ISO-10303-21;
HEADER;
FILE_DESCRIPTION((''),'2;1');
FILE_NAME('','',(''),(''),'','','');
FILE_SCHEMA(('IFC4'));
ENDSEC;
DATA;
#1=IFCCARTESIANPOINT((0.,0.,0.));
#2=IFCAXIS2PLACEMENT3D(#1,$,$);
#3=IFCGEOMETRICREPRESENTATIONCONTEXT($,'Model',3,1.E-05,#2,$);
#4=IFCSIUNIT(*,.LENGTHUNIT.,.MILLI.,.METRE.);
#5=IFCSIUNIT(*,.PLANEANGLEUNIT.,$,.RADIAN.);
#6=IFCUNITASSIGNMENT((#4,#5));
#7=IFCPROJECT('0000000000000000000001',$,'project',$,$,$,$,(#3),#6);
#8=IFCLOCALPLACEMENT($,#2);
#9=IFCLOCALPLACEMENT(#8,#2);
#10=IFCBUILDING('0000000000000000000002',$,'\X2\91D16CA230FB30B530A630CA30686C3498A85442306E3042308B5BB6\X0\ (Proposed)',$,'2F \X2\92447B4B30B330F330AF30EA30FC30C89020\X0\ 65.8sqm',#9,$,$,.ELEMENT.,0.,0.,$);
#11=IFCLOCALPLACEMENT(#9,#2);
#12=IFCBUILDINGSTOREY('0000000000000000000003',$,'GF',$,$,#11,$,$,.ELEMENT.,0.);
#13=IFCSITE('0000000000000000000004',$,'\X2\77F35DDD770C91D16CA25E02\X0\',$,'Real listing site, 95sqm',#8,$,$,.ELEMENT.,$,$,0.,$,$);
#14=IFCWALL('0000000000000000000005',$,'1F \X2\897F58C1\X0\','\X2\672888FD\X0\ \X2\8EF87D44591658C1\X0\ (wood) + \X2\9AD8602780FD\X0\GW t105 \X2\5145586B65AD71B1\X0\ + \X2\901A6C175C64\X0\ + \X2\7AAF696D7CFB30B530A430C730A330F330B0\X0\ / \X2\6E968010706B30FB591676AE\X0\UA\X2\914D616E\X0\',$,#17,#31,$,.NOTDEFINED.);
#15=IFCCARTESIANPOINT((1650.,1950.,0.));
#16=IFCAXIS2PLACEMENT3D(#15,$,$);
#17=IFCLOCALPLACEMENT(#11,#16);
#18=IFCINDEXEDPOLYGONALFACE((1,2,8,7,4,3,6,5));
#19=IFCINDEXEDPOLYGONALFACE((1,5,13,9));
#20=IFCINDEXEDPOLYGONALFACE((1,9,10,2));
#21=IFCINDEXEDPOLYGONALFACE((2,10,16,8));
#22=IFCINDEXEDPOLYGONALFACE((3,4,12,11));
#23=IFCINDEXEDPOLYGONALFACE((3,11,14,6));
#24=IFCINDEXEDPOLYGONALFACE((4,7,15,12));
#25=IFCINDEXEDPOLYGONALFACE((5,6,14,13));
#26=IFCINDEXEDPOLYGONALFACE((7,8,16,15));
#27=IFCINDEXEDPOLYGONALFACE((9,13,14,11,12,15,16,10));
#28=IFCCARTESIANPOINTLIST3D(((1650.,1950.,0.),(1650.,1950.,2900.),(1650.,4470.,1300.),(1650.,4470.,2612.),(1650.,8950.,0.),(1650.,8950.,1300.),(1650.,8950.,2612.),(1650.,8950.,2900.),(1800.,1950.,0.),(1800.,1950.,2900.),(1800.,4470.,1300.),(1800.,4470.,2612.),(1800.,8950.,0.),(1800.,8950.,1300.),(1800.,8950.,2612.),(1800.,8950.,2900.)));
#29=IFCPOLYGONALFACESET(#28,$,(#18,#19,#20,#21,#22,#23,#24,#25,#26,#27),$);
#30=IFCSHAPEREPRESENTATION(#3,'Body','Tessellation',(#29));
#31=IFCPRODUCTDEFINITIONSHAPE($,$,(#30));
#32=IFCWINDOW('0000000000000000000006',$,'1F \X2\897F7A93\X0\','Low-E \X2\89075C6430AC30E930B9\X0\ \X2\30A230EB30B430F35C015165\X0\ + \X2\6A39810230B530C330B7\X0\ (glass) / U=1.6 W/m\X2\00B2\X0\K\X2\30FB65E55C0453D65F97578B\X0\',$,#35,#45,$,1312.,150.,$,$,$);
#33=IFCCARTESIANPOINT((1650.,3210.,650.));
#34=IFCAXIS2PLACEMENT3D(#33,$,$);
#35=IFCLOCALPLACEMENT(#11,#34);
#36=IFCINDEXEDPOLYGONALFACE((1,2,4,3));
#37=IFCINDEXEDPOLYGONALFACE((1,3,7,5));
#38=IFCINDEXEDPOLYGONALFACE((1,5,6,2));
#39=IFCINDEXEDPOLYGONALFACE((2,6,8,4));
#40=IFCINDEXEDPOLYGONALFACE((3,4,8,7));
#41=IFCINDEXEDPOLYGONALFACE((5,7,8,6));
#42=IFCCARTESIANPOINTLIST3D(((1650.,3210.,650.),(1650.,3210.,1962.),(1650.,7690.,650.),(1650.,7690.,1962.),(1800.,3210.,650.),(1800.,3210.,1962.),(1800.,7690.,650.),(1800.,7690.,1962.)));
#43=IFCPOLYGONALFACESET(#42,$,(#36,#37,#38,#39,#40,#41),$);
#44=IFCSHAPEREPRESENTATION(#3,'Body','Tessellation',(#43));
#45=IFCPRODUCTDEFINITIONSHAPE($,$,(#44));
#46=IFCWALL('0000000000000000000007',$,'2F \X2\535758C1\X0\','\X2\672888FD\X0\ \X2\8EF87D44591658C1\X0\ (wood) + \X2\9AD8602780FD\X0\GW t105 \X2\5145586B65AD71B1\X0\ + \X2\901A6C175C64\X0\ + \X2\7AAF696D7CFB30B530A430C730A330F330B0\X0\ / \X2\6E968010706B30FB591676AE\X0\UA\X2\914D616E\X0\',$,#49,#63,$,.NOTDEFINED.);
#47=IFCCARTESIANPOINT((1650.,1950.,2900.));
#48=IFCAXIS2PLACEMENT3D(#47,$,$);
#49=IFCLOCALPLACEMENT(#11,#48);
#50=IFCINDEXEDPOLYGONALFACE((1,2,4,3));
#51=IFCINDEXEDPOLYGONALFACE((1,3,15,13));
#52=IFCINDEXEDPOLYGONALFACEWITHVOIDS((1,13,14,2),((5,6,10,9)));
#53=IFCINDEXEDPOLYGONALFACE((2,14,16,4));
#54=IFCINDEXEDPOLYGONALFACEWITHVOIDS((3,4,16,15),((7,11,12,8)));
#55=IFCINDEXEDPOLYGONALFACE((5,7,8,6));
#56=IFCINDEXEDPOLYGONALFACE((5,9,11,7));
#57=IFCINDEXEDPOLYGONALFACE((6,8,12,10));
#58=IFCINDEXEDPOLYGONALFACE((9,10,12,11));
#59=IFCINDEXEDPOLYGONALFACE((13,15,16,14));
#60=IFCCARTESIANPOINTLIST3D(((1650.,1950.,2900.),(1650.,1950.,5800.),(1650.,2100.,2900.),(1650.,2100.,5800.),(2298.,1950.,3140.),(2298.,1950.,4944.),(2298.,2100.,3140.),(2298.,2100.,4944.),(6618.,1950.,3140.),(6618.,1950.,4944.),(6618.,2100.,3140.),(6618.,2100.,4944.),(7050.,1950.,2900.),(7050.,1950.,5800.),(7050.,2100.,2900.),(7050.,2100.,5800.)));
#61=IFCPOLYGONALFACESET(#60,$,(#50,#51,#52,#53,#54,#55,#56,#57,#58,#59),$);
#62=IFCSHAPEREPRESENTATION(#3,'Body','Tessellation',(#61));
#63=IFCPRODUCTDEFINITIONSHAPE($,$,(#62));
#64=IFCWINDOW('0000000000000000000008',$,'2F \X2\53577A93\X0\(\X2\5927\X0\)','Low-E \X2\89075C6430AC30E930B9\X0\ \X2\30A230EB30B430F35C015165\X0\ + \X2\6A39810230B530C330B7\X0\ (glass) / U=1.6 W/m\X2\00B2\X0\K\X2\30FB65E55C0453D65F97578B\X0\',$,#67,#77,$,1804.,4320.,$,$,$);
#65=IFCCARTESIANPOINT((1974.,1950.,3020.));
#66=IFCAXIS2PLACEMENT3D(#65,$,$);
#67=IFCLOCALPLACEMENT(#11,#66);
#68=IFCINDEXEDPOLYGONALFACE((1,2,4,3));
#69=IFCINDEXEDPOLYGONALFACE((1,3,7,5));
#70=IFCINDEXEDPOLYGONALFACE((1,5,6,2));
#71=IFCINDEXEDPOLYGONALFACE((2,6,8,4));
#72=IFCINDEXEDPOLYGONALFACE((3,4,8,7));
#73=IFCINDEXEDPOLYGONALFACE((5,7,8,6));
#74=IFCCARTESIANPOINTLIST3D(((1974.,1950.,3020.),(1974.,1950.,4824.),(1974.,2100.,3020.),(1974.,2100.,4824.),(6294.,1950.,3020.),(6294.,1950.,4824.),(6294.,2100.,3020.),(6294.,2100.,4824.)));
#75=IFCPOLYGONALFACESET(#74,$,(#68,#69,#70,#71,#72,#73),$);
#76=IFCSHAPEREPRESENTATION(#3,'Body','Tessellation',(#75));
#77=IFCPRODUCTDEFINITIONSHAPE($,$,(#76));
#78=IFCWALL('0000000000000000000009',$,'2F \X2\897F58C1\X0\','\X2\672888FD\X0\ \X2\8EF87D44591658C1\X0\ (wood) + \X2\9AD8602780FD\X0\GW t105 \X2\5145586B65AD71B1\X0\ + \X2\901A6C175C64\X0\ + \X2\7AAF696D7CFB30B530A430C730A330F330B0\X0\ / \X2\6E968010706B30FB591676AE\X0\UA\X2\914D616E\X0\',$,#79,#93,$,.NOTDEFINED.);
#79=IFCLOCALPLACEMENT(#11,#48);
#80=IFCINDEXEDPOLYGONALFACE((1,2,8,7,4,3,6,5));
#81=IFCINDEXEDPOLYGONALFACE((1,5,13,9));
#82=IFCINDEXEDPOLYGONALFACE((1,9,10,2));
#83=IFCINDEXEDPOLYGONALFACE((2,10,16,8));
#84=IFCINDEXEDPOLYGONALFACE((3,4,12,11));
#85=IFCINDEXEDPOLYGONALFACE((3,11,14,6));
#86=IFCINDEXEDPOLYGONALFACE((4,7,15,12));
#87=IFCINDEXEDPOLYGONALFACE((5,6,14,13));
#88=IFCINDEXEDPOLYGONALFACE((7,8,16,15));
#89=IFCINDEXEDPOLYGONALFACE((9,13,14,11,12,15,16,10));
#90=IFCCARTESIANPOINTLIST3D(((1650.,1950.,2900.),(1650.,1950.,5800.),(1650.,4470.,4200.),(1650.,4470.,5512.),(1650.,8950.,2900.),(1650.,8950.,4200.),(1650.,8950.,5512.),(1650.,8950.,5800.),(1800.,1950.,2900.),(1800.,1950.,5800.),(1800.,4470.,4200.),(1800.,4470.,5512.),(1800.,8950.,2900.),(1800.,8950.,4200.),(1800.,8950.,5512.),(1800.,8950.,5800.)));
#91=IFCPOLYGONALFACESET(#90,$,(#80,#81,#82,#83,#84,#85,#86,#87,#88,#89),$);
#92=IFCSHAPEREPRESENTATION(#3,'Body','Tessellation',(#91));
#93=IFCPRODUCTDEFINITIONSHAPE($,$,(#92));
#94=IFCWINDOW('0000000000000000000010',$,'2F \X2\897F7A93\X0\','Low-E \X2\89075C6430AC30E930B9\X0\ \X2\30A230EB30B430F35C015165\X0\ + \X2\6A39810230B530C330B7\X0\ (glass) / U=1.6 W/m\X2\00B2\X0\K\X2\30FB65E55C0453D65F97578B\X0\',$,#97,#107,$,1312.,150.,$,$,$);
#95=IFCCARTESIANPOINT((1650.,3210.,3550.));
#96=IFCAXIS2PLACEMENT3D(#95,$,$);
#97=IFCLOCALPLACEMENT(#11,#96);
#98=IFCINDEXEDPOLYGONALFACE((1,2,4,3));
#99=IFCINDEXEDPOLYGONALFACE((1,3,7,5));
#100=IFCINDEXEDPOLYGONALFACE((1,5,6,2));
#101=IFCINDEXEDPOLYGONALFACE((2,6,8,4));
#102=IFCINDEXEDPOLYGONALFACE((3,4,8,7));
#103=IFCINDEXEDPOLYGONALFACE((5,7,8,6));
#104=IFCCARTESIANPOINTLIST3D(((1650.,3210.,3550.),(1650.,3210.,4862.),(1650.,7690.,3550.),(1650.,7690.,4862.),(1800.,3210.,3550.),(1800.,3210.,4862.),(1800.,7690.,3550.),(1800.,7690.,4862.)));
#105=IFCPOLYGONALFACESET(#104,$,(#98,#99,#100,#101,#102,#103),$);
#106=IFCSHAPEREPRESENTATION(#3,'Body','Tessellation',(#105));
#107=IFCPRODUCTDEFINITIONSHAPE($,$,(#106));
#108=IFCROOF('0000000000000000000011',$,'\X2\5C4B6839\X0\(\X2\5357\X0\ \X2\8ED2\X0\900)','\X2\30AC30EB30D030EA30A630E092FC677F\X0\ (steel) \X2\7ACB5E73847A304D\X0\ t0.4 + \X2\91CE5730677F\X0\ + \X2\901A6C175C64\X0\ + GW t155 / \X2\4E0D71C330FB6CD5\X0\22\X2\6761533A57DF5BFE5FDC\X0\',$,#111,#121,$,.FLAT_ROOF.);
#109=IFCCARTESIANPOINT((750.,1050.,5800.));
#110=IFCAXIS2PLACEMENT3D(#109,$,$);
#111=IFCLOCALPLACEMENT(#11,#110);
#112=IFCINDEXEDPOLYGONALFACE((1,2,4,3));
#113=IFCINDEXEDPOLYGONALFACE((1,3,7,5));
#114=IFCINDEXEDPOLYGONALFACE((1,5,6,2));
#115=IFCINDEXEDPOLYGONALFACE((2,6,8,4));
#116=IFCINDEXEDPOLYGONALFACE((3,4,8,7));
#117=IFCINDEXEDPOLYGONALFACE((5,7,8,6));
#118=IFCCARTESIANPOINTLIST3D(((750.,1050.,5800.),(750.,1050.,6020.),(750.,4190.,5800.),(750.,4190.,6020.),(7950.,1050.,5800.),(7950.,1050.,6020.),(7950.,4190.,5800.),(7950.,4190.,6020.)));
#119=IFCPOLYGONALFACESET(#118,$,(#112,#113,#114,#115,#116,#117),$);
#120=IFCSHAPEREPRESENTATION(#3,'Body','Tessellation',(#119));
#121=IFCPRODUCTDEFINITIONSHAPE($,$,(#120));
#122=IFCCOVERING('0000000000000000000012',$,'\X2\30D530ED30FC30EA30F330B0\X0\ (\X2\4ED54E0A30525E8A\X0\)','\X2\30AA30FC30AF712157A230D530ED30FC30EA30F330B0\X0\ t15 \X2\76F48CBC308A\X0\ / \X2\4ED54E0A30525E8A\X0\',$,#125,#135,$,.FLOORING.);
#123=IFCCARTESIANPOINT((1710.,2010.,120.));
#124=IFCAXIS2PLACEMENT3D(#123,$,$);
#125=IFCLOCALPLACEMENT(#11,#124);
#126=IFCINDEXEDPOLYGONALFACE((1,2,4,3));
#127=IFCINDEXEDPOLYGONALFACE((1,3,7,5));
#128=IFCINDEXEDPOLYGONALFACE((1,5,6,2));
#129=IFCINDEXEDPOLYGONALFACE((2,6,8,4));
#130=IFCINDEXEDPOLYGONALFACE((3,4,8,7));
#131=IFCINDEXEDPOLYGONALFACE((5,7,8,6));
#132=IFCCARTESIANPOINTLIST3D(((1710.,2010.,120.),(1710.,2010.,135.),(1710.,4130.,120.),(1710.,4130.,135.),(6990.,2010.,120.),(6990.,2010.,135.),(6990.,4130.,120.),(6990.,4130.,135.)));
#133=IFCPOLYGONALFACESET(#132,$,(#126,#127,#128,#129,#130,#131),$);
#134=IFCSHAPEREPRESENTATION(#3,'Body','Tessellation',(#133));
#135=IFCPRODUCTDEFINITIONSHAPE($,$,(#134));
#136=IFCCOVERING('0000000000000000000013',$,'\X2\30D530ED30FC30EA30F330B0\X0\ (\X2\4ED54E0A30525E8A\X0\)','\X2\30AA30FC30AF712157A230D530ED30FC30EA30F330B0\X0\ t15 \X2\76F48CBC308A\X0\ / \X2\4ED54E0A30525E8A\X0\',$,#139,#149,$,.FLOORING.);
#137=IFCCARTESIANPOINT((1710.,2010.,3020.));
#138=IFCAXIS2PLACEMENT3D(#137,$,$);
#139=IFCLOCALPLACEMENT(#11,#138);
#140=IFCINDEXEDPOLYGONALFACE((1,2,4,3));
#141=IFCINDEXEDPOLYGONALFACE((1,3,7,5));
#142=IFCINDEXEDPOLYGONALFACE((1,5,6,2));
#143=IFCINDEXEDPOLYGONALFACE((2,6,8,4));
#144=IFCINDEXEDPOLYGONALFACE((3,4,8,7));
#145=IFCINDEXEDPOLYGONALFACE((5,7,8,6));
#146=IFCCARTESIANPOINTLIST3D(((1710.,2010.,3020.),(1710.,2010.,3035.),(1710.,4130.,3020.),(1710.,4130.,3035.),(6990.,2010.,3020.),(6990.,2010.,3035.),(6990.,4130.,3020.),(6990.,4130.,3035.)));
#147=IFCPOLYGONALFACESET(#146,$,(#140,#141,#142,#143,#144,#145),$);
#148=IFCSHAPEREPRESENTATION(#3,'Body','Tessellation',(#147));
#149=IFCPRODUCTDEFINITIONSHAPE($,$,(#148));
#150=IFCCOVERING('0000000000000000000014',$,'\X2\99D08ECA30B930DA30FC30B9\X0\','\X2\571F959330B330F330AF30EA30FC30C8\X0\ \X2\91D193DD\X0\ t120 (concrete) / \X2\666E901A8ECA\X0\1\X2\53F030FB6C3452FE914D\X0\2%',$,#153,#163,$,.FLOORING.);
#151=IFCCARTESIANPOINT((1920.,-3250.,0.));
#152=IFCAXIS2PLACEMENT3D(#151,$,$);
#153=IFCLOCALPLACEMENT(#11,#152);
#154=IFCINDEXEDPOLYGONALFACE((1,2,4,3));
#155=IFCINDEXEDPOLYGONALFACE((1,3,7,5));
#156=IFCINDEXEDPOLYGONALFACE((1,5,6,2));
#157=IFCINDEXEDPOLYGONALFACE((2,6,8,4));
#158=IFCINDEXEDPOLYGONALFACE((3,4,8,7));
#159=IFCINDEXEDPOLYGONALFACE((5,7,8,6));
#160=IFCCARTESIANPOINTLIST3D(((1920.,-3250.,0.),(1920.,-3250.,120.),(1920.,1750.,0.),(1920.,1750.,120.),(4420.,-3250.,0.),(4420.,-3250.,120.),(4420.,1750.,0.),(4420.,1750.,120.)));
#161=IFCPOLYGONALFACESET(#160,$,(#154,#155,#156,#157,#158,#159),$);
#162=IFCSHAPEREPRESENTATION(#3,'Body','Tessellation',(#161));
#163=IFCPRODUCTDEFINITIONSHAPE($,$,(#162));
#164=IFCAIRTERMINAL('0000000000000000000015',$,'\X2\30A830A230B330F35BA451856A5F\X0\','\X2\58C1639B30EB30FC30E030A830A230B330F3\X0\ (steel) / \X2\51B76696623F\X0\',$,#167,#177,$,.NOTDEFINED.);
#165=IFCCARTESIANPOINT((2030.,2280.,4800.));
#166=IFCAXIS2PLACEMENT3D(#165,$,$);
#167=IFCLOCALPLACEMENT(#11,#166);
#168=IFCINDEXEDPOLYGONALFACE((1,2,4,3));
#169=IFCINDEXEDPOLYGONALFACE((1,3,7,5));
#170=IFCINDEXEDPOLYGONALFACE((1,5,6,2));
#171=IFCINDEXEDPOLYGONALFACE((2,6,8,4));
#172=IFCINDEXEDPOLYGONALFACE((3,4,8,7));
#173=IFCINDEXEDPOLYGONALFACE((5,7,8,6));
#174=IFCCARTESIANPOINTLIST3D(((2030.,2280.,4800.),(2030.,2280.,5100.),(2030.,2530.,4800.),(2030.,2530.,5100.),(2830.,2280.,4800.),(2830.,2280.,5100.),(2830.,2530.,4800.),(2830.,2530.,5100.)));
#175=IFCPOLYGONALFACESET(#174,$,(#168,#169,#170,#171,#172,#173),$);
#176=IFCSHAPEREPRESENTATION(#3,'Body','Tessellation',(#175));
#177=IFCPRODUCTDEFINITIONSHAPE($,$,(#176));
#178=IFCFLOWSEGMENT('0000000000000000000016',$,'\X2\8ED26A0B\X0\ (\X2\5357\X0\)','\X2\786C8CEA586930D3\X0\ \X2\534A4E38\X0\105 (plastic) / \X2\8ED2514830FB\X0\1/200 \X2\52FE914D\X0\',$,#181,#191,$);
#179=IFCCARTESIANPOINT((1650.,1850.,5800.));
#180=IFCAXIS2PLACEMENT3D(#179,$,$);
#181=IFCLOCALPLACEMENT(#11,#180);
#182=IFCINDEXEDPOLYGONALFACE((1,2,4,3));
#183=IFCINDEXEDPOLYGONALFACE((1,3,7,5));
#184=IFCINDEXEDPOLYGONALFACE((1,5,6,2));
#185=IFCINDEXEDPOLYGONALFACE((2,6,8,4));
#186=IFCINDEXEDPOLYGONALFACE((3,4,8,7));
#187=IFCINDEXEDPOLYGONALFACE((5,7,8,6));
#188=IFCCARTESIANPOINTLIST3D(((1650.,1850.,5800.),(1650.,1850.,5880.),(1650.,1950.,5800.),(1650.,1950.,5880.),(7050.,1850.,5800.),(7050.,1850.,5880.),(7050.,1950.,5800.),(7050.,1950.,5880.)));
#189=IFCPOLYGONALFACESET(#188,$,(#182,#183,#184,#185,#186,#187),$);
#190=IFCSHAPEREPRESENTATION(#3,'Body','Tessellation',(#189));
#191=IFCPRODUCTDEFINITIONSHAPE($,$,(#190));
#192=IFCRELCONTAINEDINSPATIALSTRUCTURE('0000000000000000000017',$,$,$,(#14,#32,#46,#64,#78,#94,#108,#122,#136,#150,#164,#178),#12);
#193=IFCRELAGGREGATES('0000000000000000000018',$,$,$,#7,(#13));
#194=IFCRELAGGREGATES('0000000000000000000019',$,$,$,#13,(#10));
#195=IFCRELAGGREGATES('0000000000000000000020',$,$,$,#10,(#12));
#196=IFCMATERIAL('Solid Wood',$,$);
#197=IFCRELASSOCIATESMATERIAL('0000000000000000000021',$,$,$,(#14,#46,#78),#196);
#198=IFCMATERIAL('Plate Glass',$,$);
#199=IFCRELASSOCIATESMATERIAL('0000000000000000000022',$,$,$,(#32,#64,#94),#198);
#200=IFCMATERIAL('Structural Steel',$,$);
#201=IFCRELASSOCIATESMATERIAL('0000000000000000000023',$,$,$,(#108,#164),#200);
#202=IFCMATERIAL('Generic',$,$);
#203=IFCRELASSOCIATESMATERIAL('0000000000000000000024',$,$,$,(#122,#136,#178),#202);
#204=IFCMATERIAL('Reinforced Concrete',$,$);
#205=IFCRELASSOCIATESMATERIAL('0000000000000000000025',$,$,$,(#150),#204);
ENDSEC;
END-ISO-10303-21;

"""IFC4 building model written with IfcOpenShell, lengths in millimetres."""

from ifc_helpers import new_model, si_unit, frame, frame_2d, origin, place, context, project, spatial, rectangle, extrude, material, element, fill, save


model = new_model("IFC4")

# Units and contexts
model_context = context("Model", 3, precision=1e-05, world=origin())
ifc_project = project(units=[si_unit("LENGTHUNIT", "METRE", prefix="MILLI"), si_unit("PLANEANGLEUNIT", "RADIAN")], contexts=[model_context])

# Site, building, storey
site_placement = place(None, origin())
site = spatial("IfcSite", under=ifc_project, at=site_placement, Name="石川県金沢市", ObjectType="Real listing site, 95sqm", CompositionType="ELEMENT", RefElevation=0.0)
building_placement = place(site_placement, origin())
building = spatial("IfcBuilding", under=site, at=building_placement, Name="金沢・サウナと水風呂のある家 (Proposed)", ObjectType="2F 鉄筋コンクリート造 65.8sqm", CompositionType="ELEMENT", ElevationOfRefHeight=0.0, ElevationOfTerrain=0.0)
storey_placement = place(building_placement, origin())
storey = spatial("IfcBuildingStorey", under=building, at=storey_placement, Name="GF", CompositionType="ELEMENT", Elevation=0.0)

# Shared definitions
ifc_material_1 = material(Name="Solid Wood")

# Shared definitions
ifc_material_2 = material(Name="Reinforced Concrete")

# Shared definitions
ifc_material_3 = material(Name="Plate Glass")

# Walls, openings, windows
wall_1_placement = place(storey_placement, frame((1650.0, 1950.0, 0.0)))
wall_1 = element("IfcWall", 1, at=wall_1_placement, inside=storey, material=ifc_material_1, Name="1F 西壁", Description="木製 軸組外壁 (wood) + 高性能GW t105 充填断熱 + 通気層 + 窯業系サイディング / 準耐火・外皮UA配慮", PredefinedType="NOTDEFINED", context=model_context, shape_type="SweptSolid", body=[
    extrude(rectangle(XDim=150.0, YDim=7000.0, at=frame_2d((75.0, 3500.0))), frame((1650.0, 1950.0, 0.0)), (0.0, 0.0, 1.0), 2900.0),
])
opening_1_placement = place(storey_placement, frame((1650.0, 3210.0, 650.0)))
opening_1 = element("IfcOpeningElement", 2, at=opening_1_placement, cuts=wall_1, PredefinedType="NOTDEFINED", context=model_context, shape_type="SweptSolid", body=[
    extrude(rectangle(XDim=150.0, YDim=4480.0, at=frame_2d((75.0, 2240.0))), frame((1650.0, 3210.0, 650.0)), (0.0, 0.0, 1.0), 1312.0),
])
window_1_placement = place(storey_placement, frame((1650.0, 3210.0, 650.0)))
window_1 = element("IfcWindow", 3, at=window_1_placement, inside=storey, material=ifc_material_3, Name="1F 西窓", Description="Low-E 複層ガラス アルゴン封入 + 樹脂サッシ (glass) / U=1.6 W/m²K・日射取得型", OverallHeight=1312.0, OverallWidth=150.0, context=model_context, shape_type="SweptSolid", body=[
    extrude(rectangle(XDim=150.0, YDim=4480.0, at=frame_2d((75.0, 2240.0))), frame((1650.0, 3210.0, 650.0)), (0.0, 0.0, 1.0), 1312.0),
])
fill(opening_1, window_1)
wall_2_placement = place(storey_placement, frame((1650.0, 1950.0, 2900.0)))
wall_2 = element("IfcWall", 4, at=wall_2_placement, inside=storey, material=ifc_material_1, Name="2F 南壁", Description="木製 軸組外壁 (wood) + 高性能GW t105 充填断熱 + 通気層 + 窯業系サイディング / 準耐火・外皮UA配慮", PredefinedType="NOTDEFINED", context=model_context, shape_type="SweptSolid", body=[
    extrude(rectangle(XDim=5400.0, YDim=150.0, at=frame_2d((2700.0, 75.0))), frame((1650.0, 1950.0, 2900.0)), (0.0, 0.0, 1.0), 2900.0),
])
opening_2_placement = place(storey_placement, frame((1974.0, 1950.0, 3020.0)))
opening_2 = element("IfcOpeningElement", 5, at=opening_2_placement, cuts=wall_2, PredefinedType="NOTDEFINED", context=model_context, shape_type="SweptSolid", body=[
    extrude(rectangle(XDim=4320.0, YDim=150.0, at=frame_2d((2160.0, 75.0))), frame((1974.0, 1950.0, 3020.0)), (0.0, 0.0, 1.0), 1804.0),
])
window_2_placement = place(storey_placement, frame((1974.0, 1950.0, 3020.0)))
window_2 = element("IfcWindow", 6, at=window_2_placement, inside=storey, material=ifc_material_3, Name="2F 南窓(大)", Description="Low-E 複層ガラス アルゴン封入 + 樹脂サッシ (glass) / U=1.6 W/m²K・日射取得型", OverallHeight=1804.0, OverallWidth=4320.0, context=model_context, shape_type="SweptSolid", body=[
    extrude(rectangle(XDim=4320.0, YDim=150.0, at=frame_2d((2160.0, 75.0))), frame((1974.0, 1950.0, 3020.0)), (0.0, 0.0, 1.0), 1804.0),
])
fill(opening_2, window_2)
wall_3_placement = place(storey_placement, frame((1650.0, 1950.0, 2900.0)))
wall_3 = element("IfcWall", 7, at=wall_3_placement, inside=storey, material=ifc_material_1, Name="2F 西壁", Description="木製 軸組外壁 (wood) + 高性能GW t105 充填断熱 + 通気層 + 窯業系サイディング / 準耐火・外皮UA配慮", PredefinedType="NOTDEFINED", context=model_context, shape_type="SweptSolid", body=[
    extrude(rectangle(XDim=150.0, YDim=7000.0, at=frame_2d((75.0, 3500.0))), frame((1650.0, 1950.0, 2900.0)), (0.0, 0.0, 1.0), 2900.0),
])
opening_3_placement = place(storey_placement, frame((1650.0, 3210.0, 3550.0)))
opening_3 = element("IfcOpeningElement", 8, at=opening_3_placement, cuts=wall_3, PredefinedType="NOTDEFINED", context=model_context, shape_type="SweptSolid", body=[
    extrude(rectangle(XDim=150.0, YDim=4480.0, at=frame_2d((75.0, 2240.0))), frame((1650.0, 3210.0, 3550.0)), (0.0, 0.0, 1.0), 1312.0),
])
window_3_placement = place(storey_placement, frame((1650.0, 3210.0, 3550.0)))
window_3 = element("IfcWindow", 9, at=window_3_placement, inside=storey, material=ifc_material_3, Name="2F 西窓", Description="Low-E 複層ガラス アルゴン封入 + 樹脂サッシ (glass) / U=1.6 W/m²K・日射取得型", OverallHeight=1312.0, OverallWidth=150.0, context=model_context, shape_type="SweptSolid", body=[
    extrude(rectangle(XDim=150.0, YDim=4480.0, at=frame_2d((75.0, 2240.0))), frame((1650.0, 3210.0, 3550.0)), (0.0, 0.0, 1.0), 1312.0),
])
fill(opening_3, window_3)

# Roof
ifc_material_4 = material(Name="Structural Steel")
for number, where, name in (
    (10, (750.0, 1050.0, 5800.0), "屋根(南 軒900)"),
):
    element("IfcRoof", number, at=place(storey_placement, frame(where)), inside=storey, material=ifc_material_4, Name=name, Description="ガルバリウム鋼板 (steel) 立平葺き t0.4 + 野地板 + 通気層 + GW t155 / 不燃・法22条区域対応", PredefinedType="FLAT_ROOF", context=model_context, shape_type="SweptSolid", body=[
        extrude(rectangle(XDim=7200.0, YDim=3140.0, at=frame_2d((3600.0, 1570.0))), frame((750.0, 1050.0, 5800.0)), (0.0, 0.0, 1.0), 220.0),
    ])

# Coverings
ifc_material_5 = material(Name="Generic")
covering_1_placement = place(storey_placement, frame((1710.0, 2010.0, 120.0)))
element("IfcCovering", 11, at=covering_1_placement, inside=storey, material=ifc_material_5, Name="フローリング (仕上げ床)", Description="オーク無垢フローリング t15 直貼り / 仕上げ床", PredefinedType="FLOORING", context=model_context, shape_type="SweptSolid", body=[
    extrude(rectangle(XDim=5280.0, YDim=2120.0, at=frame_2d((2640.0, 1060.0))), frame((1710.0, 2010.0, 120.0)), (0.0, 0.0, 1.0), 15.0),
])
covering_2_placement = place(storey_placement, frame((1710.0, 2010.0, 3020.0)))
element("IfcCovering", 12, at=covering_2_placement, inside=storey, material=ifc_material_5, Name="フローリング (仕上げ床)", Description="オーク無垢フローリング t15 直貼り / 仕上げ床", PredefinedType="FLOORING", context=model_context, shape_type="SweptSolid", body=[
    extrude(rectangle(XDim=5280.0, YDim=2120.0, at=frame_2d((2640.0, 1060.0))), frame((1710.0, 2010.0, 3020.0)), (0.0, 0.0, 1.0), 15.0),
])
covering_3_placement = place(storey_placement, frame((1920.0, -3250.0, 0.0)))
element("IfcCovering", 13, at=covering_3_placement, inside=storey, material=ifc_material_2, Name="駐車スペース", Description="土間コンクリート 金鏝 t120 (concrete) / 普通車1台・水勾配2%", PredefinedType="FLOORING", context=model_context, shape_type="SweptSolid", body=[
    extrude(rectangle(XDim=2500.0, YDim=5000.0, at=frame_2d((1250.0, 2500.0))), frame((1920.0, -3250.0, 0.0)), (0.0, 0.0, 1.0), 120.0),
])

# Air terminal
air_terminal_placement = place(storey_placement, frame((2030.0, 2280.0, 4800.0)))
element("IfcAirTerminal", 14, at=air_terminal_placement, inside=storey, material=ifc_material_4, Name="エアコン室内機", Description="壁掛ルームエアコン (steel) / 冷暖房", PredefinedType="NOTDEFINED", context=model_context, shape_type="SweptSolid", body=[
    extrude(rectangle(XDim=800.0, YDim=250.0, at=frame_2d((400.0, 125.0))), frame((2030.0, 2280.0, 4800.0)), (0.0, 0.0, 1.0), 300.0),
])

# Flow segment
flow_segment_1_placement = place(storey_placement, frame((1650.0, 1850.0, 5800.0)))
element("IfcFlowSegment", 15, at=flow_segment_1_placement, inside=storey, material=ifc_material_5, Name="軒樋 (南)", Description="硬質塩ビ 半丸105 (plastic) / 軒先・1/200 勾配", context=model_context, shape_type="SweptSolid", body=[
    extrude(rectangle(XDim=5400.0, YDim=100.0, at=frame_2d((2700.0, 50.0))), frame((1650.0, 1850.0, 5800.0)), (0.0, 0.0, 1.0), 80.0),
])

save(model, "model.ifc")
